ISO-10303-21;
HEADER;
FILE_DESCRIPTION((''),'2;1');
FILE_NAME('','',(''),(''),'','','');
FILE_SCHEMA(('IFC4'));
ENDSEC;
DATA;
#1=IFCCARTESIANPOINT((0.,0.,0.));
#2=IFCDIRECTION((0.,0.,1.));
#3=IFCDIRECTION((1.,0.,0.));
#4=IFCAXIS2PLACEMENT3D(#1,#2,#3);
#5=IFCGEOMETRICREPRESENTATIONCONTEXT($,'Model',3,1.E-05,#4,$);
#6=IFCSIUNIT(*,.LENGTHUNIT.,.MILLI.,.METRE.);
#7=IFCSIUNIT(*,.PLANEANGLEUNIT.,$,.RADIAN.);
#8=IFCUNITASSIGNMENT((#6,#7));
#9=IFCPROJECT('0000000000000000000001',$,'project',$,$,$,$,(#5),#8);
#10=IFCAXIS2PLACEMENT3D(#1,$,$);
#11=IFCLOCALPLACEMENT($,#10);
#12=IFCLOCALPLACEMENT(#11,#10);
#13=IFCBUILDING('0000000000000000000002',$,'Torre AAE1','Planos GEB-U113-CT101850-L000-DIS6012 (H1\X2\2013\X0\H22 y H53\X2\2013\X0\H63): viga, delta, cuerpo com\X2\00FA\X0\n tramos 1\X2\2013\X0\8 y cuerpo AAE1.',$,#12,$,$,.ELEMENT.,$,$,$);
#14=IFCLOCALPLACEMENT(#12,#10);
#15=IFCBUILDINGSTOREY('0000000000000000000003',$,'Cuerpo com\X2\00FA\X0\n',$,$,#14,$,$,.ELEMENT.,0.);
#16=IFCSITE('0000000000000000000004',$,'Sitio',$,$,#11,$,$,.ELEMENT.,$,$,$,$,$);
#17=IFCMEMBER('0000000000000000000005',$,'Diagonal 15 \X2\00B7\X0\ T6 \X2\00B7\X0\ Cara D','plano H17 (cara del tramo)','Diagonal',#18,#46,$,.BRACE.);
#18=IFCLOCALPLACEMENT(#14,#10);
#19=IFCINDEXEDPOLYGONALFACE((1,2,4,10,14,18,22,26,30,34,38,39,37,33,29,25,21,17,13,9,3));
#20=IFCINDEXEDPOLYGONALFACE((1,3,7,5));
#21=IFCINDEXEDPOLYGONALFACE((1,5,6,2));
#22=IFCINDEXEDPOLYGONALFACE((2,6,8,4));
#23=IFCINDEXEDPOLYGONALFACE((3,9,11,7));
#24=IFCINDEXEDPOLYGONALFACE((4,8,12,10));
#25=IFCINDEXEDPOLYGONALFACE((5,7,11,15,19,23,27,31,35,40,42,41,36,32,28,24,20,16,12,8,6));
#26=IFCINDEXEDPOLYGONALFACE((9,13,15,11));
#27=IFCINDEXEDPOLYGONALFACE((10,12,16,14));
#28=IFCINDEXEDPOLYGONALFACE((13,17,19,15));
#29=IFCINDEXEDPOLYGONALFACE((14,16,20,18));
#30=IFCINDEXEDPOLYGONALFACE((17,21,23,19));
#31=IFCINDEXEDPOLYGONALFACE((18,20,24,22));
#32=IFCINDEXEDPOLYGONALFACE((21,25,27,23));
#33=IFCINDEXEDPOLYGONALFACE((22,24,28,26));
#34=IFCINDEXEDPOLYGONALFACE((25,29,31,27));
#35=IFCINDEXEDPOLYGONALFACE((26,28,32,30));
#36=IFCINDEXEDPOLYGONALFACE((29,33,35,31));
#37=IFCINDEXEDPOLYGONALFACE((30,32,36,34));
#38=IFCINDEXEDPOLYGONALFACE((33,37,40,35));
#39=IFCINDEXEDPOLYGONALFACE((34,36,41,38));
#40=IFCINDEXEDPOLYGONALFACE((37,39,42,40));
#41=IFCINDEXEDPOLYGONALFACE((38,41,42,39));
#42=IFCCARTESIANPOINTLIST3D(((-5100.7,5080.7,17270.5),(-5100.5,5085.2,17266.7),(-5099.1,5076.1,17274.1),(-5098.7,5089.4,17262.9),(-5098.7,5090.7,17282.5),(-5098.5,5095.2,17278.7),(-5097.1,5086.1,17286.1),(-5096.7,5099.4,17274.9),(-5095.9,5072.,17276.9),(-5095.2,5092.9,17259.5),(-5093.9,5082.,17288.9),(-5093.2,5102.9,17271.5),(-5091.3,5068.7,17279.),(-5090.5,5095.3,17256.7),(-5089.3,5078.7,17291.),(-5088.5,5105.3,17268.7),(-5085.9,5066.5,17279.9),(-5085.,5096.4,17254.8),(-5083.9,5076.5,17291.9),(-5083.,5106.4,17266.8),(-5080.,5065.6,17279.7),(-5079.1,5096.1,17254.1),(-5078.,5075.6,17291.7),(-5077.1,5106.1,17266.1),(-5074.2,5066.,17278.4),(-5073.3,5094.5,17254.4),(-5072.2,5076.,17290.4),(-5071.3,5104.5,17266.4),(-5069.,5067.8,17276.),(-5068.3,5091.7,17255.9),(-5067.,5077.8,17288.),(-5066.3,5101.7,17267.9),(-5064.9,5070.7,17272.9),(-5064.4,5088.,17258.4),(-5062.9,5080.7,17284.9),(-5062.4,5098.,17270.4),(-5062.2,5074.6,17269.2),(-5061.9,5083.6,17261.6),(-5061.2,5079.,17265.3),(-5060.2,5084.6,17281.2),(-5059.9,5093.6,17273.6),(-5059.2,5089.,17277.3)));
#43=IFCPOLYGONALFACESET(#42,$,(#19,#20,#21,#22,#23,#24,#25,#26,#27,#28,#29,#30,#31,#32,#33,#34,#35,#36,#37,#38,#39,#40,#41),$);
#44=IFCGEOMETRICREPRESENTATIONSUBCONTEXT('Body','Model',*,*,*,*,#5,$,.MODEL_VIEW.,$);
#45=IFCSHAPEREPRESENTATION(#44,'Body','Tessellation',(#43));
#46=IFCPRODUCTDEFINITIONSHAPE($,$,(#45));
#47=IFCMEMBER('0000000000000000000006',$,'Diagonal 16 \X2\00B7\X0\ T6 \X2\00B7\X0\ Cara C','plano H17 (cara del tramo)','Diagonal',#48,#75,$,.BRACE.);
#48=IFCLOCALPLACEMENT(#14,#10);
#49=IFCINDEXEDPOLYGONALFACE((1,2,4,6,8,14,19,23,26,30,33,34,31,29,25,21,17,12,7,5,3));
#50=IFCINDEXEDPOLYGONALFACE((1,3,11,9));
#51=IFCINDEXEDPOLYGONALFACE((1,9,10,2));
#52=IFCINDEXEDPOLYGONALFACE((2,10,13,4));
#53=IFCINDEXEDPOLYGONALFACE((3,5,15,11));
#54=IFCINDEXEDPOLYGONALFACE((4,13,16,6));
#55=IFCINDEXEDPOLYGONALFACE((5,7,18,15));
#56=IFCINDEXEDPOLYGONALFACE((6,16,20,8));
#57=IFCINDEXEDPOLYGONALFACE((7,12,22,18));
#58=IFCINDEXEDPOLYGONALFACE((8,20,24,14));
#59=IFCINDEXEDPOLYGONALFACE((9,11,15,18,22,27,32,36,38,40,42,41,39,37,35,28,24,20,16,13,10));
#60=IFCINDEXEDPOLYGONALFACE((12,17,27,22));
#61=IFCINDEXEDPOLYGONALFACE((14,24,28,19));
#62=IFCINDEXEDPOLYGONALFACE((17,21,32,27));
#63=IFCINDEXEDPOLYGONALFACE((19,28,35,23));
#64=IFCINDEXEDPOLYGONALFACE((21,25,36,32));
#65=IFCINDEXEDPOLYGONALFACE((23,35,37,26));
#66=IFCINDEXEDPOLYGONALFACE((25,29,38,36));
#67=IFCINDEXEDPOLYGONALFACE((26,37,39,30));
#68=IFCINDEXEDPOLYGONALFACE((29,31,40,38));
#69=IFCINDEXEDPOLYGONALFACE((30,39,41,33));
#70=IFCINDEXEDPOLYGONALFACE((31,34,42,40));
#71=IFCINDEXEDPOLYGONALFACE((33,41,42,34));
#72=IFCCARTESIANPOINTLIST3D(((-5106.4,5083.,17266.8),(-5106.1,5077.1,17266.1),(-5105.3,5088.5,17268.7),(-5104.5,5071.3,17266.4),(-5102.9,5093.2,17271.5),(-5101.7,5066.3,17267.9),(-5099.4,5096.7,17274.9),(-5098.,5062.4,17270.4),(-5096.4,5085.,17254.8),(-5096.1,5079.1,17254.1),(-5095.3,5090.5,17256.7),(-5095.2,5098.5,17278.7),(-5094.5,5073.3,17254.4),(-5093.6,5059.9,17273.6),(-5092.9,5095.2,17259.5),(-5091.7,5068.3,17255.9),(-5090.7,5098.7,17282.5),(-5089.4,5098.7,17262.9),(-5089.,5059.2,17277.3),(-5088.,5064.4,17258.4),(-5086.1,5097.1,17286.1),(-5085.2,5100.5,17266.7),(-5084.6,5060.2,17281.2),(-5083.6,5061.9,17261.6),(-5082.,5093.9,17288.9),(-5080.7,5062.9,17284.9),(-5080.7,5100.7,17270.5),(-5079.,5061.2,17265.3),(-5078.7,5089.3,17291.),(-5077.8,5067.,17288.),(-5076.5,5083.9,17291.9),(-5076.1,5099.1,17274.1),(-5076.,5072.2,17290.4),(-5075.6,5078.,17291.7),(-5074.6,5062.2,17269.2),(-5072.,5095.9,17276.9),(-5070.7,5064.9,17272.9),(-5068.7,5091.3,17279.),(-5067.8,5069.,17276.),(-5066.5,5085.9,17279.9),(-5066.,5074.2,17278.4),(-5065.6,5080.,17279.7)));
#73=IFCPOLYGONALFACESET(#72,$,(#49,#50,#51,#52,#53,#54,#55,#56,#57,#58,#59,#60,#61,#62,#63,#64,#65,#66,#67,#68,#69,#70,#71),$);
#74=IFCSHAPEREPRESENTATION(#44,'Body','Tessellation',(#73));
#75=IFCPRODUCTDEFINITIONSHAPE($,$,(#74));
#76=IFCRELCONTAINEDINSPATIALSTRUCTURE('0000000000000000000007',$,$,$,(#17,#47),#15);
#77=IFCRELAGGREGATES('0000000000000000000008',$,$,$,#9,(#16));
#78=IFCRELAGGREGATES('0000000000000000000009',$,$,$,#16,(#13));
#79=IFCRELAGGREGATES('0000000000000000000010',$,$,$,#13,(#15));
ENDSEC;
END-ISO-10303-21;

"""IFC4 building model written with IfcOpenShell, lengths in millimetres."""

from ifc_helpers import new_model, si_unit, frame, origin, origin_with_axes, place, context, subcontext, project, spatial, circle, extrude, element, save


model = new_model("IFC4")

# Units and contexts
model_context = context("Model", 3, precision=1e-05, world=origin_with_axes())
body_context = subcontext(model_context, "Body", "Model", "MODEL_VIEW")
ifc_project = project(units=[si_unit("LENGTHUNIT", "METRE", prefix="MILLI"), si_unit("PLANEANGLEUNIT", "RADIAN")], contexts=[model_context])

# Site, building, storey
site_placement = place(None, origin())
site = spatial("IfcSite", under=ifc_project, at=site_placement, Name="Sitio", CompositionType="ELEMENT")
building_placement = place(site_placement, origin())
building = spatial("IfcBuilding", under=site, at=building_placement, Name="Torre AAE1", Description="Planos GEB-U113-CT101850-L000-DIS6012 (H1–H22 y H53–H63): viga, delta, cuerpo común tramos 1–8 y cuerpo AAE1.", CompositionType="ELEMENT")
storey_placement = place(building_placement, origin())
storey = spatial("IfcBuildingStorey", under=building, at=storey_placement, Name="Cuerpo común", CompositionType="ELEMENT", Elevation=0.0)

# Members
for number, where, z_axis, x_axis, name in (
    (1, (-5079.0, 5091.0, 17279.0), (-0.127, -0.635001, -0.762001), (0.806261, -0.513563, 0.293592), "Diagonal 15 · T6 · Cara D"),
    (2, (-5091.0, 5079.0, 17279.0), (0.635001, 0.127, -0.762001), (0.513563, -0.806261, 0.293592), "Diagonal 16 · T6 · Cara C"),
):
    element("IfcMember", number, at=place(storey_placement, frame(where, z_axis=z_axis, x_axis=x_axis)), inside=storey, Name=name, Description="plano H17 (cara del tramo)", ObjectType="Diagonal", PredefinedType="BRACE", context=body_context, shape_type="SweptSolid", body=[
        extrude(circle(Radius=20.0), None, (0.0, 0.0, 1.0), 15.7),
    ])

save(model, "model.ifc")
